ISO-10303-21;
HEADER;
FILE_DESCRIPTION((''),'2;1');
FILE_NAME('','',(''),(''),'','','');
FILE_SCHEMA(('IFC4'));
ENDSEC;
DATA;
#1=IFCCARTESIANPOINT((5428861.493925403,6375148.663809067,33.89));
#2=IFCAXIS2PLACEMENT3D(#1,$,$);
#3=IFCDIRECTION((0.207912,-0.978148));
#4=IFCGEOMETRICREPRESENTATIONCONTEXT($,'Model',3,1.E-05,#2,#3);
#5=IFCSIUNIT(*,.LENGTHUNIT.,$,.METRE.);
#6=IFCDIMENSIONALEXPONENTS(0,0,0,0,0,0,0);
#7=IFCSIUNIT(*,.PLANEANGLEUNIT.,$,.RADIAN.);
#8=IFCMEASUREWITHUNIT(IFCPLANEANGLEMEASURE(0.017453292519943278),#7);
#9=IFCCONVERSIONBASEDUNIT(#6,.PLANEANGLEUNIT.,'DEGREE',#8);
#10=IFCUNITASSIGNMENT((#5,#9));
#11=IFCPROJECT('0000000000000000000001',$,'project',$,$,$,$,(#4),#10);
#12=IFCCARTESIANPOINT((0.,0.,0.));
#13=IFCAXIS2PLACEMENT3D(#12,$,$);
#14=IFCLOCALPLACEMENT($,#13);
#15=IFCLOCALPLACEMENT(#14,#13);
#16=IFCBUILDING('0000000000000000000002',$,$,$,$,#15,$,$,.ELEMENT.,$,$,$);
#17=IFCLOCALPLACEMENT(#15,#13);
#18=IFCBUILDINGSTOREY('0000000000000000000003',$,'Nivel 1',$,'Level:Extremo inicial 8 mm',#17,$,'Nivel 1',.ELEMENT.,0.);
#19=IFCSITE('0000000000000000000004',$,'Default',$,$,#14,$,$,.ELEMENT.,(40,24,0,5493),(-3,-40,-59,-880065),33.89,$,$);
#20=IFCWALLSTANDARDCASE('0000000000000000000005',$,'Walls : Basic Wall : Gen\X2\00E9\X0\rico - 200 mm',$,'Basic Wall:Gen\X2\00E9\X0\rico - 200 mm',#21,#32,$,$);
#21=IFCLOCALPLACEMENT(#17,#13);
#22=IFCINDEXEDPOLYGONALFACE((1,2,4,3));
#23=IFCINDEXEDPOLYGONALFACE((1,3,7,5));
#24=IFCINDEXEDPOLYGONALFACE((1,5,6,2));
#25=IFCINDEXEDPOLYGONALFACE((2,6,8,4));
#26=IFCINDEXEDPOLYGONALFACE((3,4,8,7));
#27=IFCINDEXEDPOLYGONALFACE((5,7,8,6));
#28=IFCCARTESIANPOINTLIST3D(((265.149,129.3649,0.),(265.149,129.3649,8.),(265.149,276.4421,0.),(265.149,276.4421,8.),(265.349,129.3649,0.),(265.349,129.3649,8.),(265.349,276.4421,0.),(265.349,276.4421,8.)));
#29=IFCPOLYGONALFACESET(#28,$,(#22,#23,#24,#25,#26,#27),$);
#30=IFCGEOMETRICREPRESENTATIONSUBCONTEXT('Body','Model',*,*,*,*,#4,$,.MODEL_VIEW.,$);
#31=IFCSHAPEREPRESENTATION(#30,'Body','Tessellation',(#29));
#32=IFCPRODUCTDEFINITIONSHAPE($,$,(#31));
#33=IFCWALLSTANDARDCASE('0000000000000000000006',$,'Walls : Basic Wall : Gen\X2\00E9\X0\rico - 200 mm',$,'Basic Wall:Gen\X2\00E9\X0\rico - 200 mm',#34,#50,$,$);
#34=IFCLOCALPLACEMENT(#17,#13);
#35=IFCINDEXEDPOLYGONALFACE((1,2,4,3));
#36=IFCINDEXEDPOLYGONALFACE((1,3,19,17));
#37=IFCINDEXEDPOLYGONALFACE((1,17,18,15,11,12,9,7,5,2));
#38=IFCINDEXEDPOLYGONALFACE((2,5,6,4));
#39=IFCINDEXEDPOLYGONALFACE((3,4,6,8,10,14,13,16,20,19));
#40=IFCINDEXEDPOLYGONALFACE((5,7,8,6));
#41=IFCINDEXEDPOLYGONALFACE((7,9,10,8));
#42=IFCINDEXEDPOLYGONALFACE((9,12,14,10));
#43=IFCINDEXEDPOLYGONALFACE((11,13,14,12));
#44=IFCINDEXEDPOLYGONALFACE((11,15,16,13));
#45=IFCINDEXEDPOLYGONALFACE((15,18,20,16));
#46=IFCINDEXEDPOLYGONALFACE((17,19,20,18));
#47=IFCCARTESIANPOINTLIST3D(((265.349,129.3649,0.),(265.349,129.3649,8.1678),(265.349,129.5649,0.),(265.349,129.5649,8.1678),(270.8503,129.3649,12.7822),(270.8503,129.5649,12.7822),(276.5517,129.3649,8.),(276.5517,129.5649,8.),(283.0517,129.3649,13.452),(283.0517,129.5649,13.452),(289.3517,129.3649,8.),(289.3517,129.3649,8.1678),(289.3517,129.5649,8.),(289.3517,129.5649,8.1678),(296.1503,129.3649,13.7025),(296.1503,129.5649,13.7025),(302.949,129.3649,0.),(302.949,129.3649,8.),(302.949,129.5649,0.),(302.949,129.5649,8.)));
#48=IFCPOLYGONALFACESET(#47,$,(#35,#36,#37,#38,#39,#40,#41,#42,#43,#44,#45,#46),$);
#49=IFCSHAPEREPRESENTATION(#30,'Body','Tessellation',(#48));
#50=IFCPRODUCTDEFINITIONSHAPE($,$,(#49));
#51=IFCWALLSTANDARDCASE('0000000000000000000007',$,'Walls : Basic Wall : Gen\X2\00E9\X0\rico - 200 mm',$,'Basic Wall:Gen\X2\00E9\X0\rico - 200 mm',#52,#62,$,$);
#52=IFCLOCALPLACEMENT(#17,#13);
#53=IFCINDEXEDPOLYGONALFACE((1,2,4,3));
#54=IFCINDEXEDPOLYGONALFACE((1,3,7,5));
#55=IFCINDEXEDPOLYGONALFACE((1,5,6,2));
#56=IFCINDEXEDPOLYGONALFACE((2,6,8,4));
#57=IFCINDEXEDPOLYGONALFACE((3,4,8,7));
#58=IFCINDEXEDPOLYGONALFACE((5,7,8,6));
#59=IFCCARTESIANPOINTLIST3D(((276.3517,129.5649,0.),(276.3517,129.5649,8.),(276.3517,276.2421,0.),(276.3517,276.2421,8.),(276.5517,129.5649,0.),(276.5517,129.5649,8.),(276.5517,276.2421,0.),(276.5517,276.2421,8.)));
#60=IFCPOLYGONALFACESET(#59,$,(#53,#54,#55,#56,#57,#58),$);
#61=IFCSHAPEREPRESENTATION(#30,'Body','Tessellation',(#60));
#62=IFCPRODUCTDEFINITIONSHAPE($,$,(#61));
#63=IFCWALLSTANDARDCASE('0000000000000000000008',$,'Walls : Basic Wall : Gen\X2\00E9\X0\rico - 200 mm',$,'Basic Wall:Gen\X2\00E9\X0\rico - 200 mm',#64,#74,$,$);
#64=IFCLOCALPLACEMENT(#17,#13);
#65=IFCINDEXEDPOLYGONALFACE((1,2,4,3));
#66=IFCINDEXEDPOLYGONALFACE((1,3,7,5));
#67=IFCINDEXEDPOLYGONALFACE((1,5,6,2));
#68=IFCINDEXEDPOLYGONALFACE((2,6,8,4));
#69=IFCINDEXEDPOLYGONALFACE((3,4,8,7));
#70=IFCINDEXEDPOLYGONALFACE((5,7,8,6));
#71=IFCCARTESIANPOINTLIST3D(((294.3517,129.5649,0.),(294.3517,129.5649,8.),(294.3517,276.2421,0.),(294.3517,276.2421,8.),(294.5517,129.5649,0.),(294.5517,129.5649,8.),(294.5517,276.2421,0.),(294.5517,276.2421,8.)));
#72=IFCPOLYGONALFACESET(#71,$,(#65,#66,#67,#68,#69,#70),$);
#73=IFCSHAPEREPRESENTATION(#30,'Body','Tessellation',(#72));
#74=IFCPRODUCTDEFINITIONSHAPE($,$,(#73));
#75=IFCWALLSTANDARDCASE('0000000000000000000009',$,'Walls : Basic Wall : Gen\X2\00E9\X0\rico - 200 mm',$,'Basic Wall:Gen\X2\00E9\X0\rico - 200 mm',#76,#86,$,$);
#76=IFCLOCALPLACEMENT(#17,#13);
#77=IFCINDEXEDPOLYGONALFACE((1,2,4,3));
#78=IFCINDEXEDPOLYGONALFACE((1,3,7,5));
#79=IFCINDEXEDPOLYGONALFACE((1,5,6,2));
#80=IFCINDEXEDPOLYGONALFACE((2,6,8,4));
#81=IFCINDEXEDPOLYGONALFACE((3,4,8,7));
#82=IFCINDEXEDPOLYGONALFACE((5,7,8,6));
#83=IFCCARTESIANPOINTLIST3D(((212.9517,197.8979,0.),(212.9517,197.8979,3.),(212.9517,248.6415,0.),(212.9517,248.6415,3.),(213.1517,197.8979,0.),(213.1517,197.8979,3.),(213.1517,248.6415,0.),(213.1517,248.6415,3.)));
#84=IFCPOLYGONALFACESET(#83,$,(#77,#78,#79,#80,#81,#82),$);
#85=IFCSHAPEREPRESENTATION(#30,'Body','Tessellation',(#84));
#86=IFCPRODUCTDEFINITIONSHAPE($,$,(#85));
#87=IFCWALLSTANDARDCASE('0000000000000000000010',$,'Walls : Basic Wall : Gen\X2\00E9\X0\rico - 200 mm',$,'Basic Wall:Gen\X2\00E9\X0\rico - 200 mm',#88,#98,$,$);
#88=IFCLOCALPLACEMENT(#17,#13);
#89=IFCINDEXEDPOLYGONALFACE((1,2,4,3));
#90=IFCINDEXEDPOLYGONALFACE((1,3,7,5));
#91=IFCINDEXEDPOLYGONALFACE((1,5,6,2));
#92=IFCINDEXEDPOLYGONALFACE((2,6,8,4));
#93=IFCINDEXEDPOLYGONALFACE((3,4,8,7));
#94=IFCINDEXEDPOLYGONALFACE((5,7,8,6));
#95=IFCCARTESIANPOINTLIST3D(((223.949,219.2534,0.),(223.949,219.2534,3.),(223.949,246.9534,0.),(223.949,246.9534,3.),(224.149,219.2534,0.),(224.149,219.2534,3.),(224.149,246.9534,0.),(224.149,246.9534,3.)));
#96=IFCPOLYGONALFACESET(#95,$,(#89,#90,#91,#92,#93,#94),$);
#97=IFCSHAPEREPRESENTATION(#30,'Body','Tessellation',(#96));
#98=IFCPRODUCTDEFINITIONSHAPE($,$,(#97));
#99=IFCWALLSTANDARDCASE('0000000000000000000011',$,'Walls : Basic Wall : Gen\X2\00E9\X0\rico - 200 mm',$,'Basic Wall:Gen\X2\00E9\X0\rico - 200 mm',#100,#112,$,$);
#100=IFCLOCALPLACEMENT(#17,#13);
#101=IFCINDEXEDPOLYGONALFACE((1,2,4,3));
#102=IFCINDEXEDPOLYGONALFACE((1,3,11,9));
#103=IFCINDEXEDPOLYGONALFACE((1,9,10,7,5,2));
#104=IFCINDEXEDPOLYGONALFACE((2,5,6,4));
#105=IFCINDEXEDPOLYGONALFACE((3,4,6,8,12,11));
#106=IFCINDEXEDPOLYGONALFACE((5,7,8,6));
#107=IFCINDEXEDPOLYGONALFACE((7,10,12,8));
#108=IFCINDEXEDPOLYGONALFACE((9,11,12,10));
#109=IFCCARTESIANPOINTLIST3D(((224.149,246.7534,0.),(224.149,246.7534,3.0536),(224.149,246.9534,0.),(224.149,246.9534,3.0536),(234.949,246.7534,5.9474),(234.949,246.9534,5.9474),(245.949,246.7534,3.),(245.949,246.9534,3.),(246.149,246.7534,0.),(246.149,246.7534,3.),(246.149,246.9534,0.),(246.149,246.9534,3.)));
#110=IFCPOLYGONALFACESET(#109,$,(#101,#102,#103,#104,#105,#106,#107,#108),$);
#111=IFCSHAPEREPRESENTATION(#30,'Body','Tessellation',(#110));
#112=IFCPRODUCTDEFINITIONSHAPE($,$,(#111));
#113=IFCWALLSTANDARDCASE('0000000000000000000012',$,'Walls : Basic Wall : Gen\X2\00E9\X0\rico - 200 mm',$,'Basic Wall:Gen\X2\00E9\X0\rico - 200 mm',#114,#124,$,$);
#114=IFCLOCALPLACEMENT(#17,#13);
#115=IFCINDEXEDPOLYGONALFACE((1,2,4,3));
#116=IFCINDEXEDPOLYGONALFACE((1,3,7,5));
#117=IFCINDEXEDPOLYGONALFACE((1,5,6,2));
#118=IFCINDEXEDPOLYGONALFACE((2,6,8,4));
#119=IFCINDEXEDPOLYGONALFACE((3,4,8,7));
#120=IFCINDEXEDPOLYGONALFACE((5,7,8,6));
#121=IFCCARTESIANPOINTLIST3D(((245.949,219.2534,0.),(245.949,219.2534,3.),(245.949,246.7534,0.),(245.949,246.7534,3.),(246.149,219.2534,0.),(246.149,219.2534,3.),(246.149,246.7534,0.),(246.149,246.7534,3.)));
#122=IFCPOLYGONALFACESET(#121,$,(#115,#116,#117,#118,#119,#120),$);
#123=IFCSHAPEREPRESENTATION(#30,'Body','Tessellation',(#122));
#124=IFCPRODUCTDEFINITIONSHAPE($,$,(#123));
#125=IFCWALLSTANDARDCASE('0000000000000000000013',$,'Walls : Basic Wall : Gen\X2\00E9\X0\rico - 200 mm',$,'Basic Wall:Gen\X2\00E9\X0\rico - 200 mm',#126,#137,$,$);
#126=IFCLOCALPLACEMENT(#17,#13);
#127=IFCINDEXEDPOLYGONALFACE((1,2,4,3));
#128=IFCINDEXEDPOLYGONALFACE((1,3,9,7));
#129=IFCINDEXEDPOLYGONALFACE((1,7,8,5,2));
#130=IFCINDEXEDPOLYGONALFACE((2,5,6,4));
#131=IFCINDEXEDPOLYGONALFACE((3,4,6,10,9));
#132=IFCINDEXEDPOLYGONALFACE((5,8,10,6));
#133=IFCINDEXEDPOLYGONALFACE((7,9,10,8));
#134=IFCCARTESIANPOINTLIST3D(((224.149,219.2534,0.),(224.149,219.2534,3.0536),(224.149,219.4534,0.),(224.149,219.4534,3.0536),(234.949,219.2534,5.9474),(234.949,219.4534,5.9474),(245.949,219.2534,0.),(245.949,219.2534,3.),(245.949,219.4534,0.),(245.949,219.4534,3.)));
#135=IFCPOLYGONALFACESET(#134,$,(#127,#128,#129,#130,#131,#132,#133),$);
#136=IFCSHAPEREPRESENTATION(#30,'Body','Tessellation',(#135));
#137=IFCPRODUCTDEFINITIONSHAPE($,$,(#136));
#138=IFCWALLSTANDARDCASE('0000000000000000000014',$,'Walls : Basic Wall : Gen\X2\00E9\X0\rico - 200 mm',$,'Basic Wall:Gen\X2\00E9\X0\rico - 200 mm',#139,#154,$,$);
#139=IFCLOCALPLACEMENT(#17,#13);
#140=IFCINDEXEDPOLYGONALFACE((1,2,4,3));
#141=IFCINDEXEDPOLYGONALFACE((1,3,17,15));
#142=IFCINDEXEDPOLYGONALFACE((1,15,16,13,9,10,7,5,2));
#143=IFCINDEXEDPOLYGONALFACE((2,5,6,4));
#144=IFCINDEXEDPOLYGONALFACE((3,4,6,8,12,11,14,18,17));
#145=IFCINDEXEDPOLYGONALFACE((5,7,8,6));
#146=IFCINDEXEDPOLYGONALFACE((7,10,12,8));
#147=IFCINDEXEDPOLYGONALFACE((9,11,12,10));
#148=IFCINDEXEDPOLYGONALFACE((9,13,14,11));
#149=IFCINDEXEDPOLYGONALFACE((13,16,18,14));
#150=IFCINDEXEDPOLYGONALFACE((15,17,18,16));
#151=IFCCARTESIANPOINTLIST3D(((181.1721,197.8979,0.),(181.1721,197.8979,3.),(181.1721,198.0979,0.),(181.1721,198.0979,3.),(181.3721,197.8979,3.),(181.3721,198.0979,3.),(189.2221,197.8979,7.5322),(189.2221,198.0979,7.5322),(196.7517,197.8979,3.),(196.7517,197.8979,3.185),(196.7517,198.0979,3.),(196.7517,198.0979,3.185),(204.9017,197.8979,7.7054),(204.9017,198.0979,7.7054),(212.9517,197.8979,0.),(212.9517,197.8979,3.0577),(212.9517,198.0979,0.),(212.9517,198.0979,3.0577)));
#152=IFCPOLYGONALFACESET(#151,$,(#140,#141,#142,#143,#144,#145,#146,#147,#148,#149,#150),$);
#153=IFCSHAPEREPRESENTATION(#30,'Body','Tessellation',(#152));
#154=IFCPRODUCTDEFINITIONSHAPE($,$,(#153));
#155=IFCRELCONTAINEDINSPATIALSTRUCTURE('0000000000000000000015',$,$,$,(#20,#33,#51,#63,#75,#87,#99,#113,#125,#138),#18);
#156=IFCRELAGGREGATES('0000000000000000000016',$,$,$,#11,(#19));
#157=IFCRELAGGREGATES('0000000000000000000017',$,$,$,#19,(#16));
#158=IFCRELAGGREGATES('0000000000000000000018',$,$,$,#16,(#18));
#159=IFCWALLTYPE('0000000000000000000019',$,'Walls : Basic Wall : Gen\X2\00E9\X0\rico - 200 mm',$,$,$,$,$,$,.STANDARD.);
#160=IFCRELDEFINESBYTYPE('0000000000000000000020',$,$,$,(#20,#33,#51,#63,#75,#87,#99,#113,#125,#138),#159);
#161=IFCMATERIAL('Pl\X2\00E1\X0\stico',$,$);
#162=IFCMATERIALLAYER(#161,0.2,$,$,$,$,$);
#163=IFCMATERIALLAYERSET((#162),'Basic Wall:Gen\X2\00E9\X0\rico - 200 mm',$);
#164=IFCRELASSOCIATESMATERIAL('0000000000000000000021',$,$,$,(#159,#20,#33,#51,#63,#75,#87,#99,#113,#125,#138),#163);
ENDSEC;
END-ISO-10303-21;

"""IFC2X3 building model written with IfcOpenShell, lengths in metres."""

from ifc_helpers import new_model, entity, si_unit, converted_unit, direction, frame, frame_2d, origin, place, context, subcontext, project, spatial, polyline, rectangle, extrude, clip, bounded_halfspace, material, layer, layer_set, layer_usage, type_object, element, save


model = new_model("IFC2X3")

# Units and contexts
model_context = context("Model", 3, precision=1e-05, world=frame((5428861.493925403, 6375148.663809067, 33.89)), true_north=direction((0.207912, -0.978148)))
body_context = subcontext(model_context, "Body", "Model", "MODEL_VIEW")
ifc_project = project(units=[si_unit("LENGTHUNIT", "METRE"), converted_unit("PLANEANGLEUNIT", "DEGREE", entity("IfcPlaneAngleMeasure", 0.017453292519943278), si_unit("PLANEANGLEUNIT", "RADIAN"), dimensions=[0, 0, 0, 0, 0, 0, 0])], contexts=[model_context])

# Site, building, storey
site_placement = place(None, origin())
site = spatial("IfcSite", under=ifc_project, at=site_placement, Name="Default", CompositionType="ELEMENT", RefLatitude=(40, 24, 0, 5493), RefLongitude=(-3, -40, -59, -880065), RefElevation=33.89)
building_placement = place(site_placement, origin())
building = spatial("IfcBuilding", under=site, at=building_placement, CompositionType="ELEMENT")
storey_placement = place(building_placement, origin())
storey = spatial("IfcBuildingStorey", under=building, at=storey_placement, Name="Nivel 1", ObjectType="Level:Extremo inicial 8 mm", LongName="Nivel 1", CompositionType="ELEMENT", Elevation=0.0)

# Walls
ifc_material_1 = material(Name="Plástico")
ifc_layer_1 = layer(ifc_material_1, 0.2)
ifc_layer_set_1 = layer_set([ifc_layer_1], Name="Basic Wall:Genérico - 200 mm")
ifc_layer_usage_1 = layer_usage(ifc_layer_set_1, "AXIS2", "NEGATIVE", 0.1)
wall_type = type_object("IfcWallType", Name="Walls : Basic Wall : Genérico - 200 mm", PredefinedType="STANDARD", material=ifc_layer_set_1)
wall_1_placement = place(storey_placement, frame((265.249, 129.3649, 0.0), z_axis=(0.0, 0.0, 1.0), x_axis=(0.0, 1.0, 0.0)))
element("IfcWallStandardCase", 1, at=wall_1_placement, inside=storey, type_object=wall_type, material=ifc_layer_usage_1, Name="Walls : Basic Wall : Genérico - 200 mm", ObjectType="Basic Wall:Genérico - 200 mm", context=body_context, shape_type="SweptSolid", body=[
    extrude(rectangle(XDim=147.0772, YDim=0.2, at=frame_2d((73.5386, 0.0), x_axis=(-1.0, 0.0))), origin(), (0.0, 0.0, 1.0), 8.0),
])
ifc_layer_usage_2 = layer_usage(ifc_layer_set_1, "AXIS2", "NEGATIVE", 0.1)
wall_2_placement = place(storey_placement, frame((302.949, 129.4649, 0.0), z_axis=(0.0, 0.0, 1.0), x_axis=(-1.0, 0.0, 0.0)))
element("IfcWallStandardCase", 2, at=wall_2_placement, inside=storey, type_object=wall_type, material=ifc_layer_usage_2, Name="Walls : Basic Wall : Genérico - 200 mm", ObjectType="Basic Wall:Genérico - 200 mm", context=body_context, shape_type="Clipping", body=[
    clip(clip(clip(clip(clip(clip(extrude(rectangle(XDim=37.6, YDim=0.2, at=frame_2d((18.8, 0.0), x_axis=(-1.0, 0.0))), origin(), (0.0, 0.0, 1.0), 13.7025), bounded_halfspace(frame((32.0986, -0.1, 12.7822), z_axis=(0.642641, 0.0, 0.766167), x_axis=(0.0, 1.0, 0.0)), False, frame((32.0986, -0.1, 12.7822)), polyline([(0.0, 0.0), (5.5014, 0.0), (5.5014, 0.2), (0.0, 0.2), (0.0, 0.0)]))), bounded_halfspace(frame((19.8973, -0.1, 13.452), z_axis=(0.642641, 0.0, 0.766167), x_axis=(0.0, 1.0, 0.0)), False, frame((19.8973, -0.1, 13.452)), polyline([(0.0, 0.0), (6.5, 0.0), (6.5, 0.2), (0.0, 0.2), (0.0, 0.0)]))), bounded_halfspace(frame((13.5973, -0.1, 8.0), z_axis=(0.642641, 0.0, 0.766167), x_axis=(0.0, 1.0, 0.0)), False, frame((13.5973, -0.1, 8.0)), polyline([(0.0, 0.0), (0.0, 0.2), (-6.7986, 0.2), (-6.7986, 0.0), (0.0, 0.0)]))), bounded_halfspace(frame((26.3973, -0.1, 8.0), z_axis=(-0.642641, 0.0, 0.766167), x_axis=(0.0, -1.0, 0.0)), False, frame((26.3973, -0.1, 8.0)), polyline([(0.0, 0.0), (5.7014, 0.0), (5.7014, 0.2), (0.0, 0.2), (0.0, 0.0)]))), bounded_halfspace(frame((13.5973, -0.1, 8.1678), z_axis=(-0.642641, 0.0, 0.766167), x_axis=(0.0, -1.0, 0.0)), False, frame((13.5973, -0.1, 8.1678)), polyline([(0.0, 0.0), (6.3, 0.0), (6.3, 0.2), (0.0, 0.2), (0.0, 0.0)]))), bounded_halfspace(frame((6.7986, 0.1, 13.7025), z_axis=(-0.642641, 0.0, 0.766167), x_axis=(0.0, -1.0, 0.0)), False, frame((6.7986, 0.1, 13.7025)), polyline([(0.0, 0.0), (-6.7986, 0.0), (-6.7986, -0.2), (0.0, -0.2), (0.0, 0.0)]))),
])
ifc_layer_usage_3 = layer_usage(ifc_layer_set_1, "AXIS2", "NEGATIVE", 0.1)
wall_3_placement = place(storey_placement, frame((276.4517, 129.5649, 0.0), z_axis=(0.0, 0.0, 1.0), x_axis=(0.0, 1.0, 0.0)))
element("IfcWallStandardCase", 3, at=wall_3_placement, inside=storey, type_object=wall_type, material=ifc_layer_usage_3, Name="Walls : Basic Wall : Genérico - 200 mm", ObjectType="Basic Wall:Genérico - 200 mm", context=body_context, shape_type="SweptSolid", body=[
    extrude(rectangle(XDim=146.6772, YDim=0.2, at=frame_2d((73.3386, 0.0), x_axis=(-1.0, 0.0))), origin(), (0.0, 0.0, 1.0), 8.0),
])
ifc_layer_usage_4 = layer_usage(ifc_layer_set_1, "AXIS2", "NEGATIVE", 0.1)
wall_4_placement = place(storey_placement, frame((294.4517, 129.5649, 0.0), z_axis=(0.0, 0.0, 1.0), x_axis=(0.0, 1.0, 0.0)))
element("IfcWallStandardCase", 4, at=wall_4_placement, inside=storey, type_object=wall_type, material=ifc_layer_usage_4, Name="Walls : Basic Wall : Genérico - 200 mm", ObjectType="Basic Wall:Genérico - 200 mm", context=body_context, shape_type="SweptSolid", body=[
    extrude(rectangle(XDim=146.6772, YDim=0.2, at=frame_2d((73.3386, 0.0), x_axis=(-1.0, 0.0))), origin(), (0.0, 0.0, 1.0), 8.0),
])
ifc_layer_usage_5 = layer_usage(ifc_layer_set_1, "AXIS2", "NEGATIVE", 0.1)
wall_5_placement = place(storey_placement, frame((213.0517, 248.6415, 0.0), z_axis=(0.0, 0.0, 1.0), x_axis=(0.0, -1.0, 0.0)))
element("IfcWallStandardCase", 5, at=wall_5_placement, inside=storey, type_object=wall_type, material=ifc_layer_usage_5, Name="Walls : Basic Wall : Genérico - 200 mm", ObjectType="Basic Wall:Genérico - 200 mm", context=body_context, shape_type="SweptSolid", body=[
    extrude(rectangle(XDim=50.7436, YDim=0.2, at=frame_2d((25.3718, 0.0), x_axis=(-1.0, 0.0))), origin(), (0.0, 0.0, 1.0), 3.0),
])
ifc_layer_usage_6 = layer_usage(ifc_layer_set_1, "AXIS2", "NEGATIVE", 0.1)
wall_6_placement = place(storey_placement, frame((224.049, 219.2534, 0.0), z_axis=(0.0, 0.0, 1.0), x_axis=(0.0, 1.0, 0.0)))
element("IfcWallStandardCase", 6, at=wall_6_placement, inside=storey, type_object=wall_type, material=ifc_layer_usage_6, Name="Walls : Basic Wall : Genérico - 200 mm", ObjectType="Basic Wall:Genérico - 200 mm", context=body_context, shape_type="SweptSolid", body=[
    extrude(rectangle(XDim=27.7, YDim=0.2, at=frame_2d((13.85, 0.0), x_axis=(-1.0, 0.0))), origin(), (0.0, 0.0, 1.0), 3.0),
])
ifc_layer_usage_7 = layer_usage(ifc_layer_set_1, "AXIS2", "NEGATIVE", 0.1)
wall_7_placement = place(storey_placement, frame((224.149, 246.8534, 0.0)))
element("IfcWallStandardCase", 7, at=wall_7_placement, inside=storey, type_object=wall_type, material=ifc_layer_usage_7, Name="Walls : Basic Wall : Genérico - 200 mm", ObjectType="Basic Wall:Genérico - 200 mm", context=body_context, shape_type="Clipping", body=[
    clip(clip(clip(extrude(rectangle(XDim=22.0, YDim=0.2, at=frame_2d((11.0, 0.0), x_axis=(-1.0, 0.0))), origin(), (0.0, 0.0, 1.0), 5.9474), bounded_halfspace(frame((0.0, -0.1, 3.0536), z_axis=(-0.258819, 0.0, 0.965926), x_axis=(0.0, -1.0, 0.0)), False, frame((0.0, -0.1, 3.0536)), polyline([(0.0, 0.0), (10.8, 0.0), (10.8, 0.2), (0.0, 0.2), (0.0, 0.0)]))), bounded_halfspace(frame((10.8, -0.1, 5.9474), z_axis=(0.258819, 0.0, 0.965926), x_axis=(0.0, 1.0, 0.0)), False, frame((10.8, -0.1, 5.9474)), polyline([(0.0, 0.0), (11.0, 0.0), (11.0, 0.2), (0.0, 0.2), (0.0, 0.0)]))), bounded_halfspace(frame((21.8, -0.1, 3.0), z_axis=(0.0, 0.0, 1.0), x_axis=(0.0, 1.0, 0.0)), False, frame((21.8, -0.1, 3.0)), polyline([(0.0, 0.0), (0.2, 0.0), (0.2, 0.2), (0.0, 0.2), (0.0, 0.0)]))),
])
ifc_layer_usage_8 = layer_usage(ifc_layer_set_1, "AXIS2", "NEGATIVE", 0.1)
wall_8_placement = place(storey_placement, frame((246.049, 246.7534, 0.0), z_axis=(0.0, 0.0, 1.0), x_axis=(0.0, -1.0, 0.0)))
element("IfcWallStandardCase", 8, at=wall_8_placement, inside=storey, type_object=wall_type, material=ifc_layer_usage_8, Name="Walls : Basic Wall : Genérico - 200 mm", ObjectType="Basic Wall:Genérico - 200 mm", context=body_context, shape_type="SweptSolid", body=[
    extrude(rectangle(XDim=27.5, YDim=0.2, at=frame_2d((13.75, 0.0), x_axis=(-1.0, 0.0))), origin(), (0.0, 0.0, 1.0), 3.0),
])
ifc_layer_usage_9 = layer_usage(ifc_layer_set_1, "AXIS2", "NEGATIVE", 0.1)
wall_9_placement = place(storey_placement, frame((245.949, 219.3534, 0.0), z_axis=(0.0, 0.0, 1.0), x_axis=(-1.0, 0.0, 0.0)))
element("IfcWallStandardCase", 9, at=wall_9_placement, inside=storey, type_object=wall_type, material=ifc_layer_usage_9, Name="Walls : Basic Wall : Genérico - 200 mm", ObjectType="Basic Wall:Genérico - 200 mm", context=body_context, shape_type="Clipping", body=[
    clip(clip(extrude(rectangle(XDim=21.8, YDim=0.2, at=frame_2d((10.9, 0.0), x_axis=(-1.0, 0.0))), origin(), (0.0, 0.0, 1.0), 5.9474), bounded_halfspace(frame((11.0, -0.1, 5.9474), z_axis=(0.258819, 0.0, 0.965926), x_axis=(0.0, 1.0, 0.0)), False, frame((11.0, -0.1, 5.9474)), polyline([(0.0, 0.0), (10.8, 0.0), (10.8, 0.2), (0.0, 0.2), (0.0, 0.0)]))), bounded_halfspace(frame((0.0, -0.1, 3.0), z_axis=(-0.258819, 0.0, 0.965926), x_axis=(0.0, -1.0, 0.0)), False, frame((0.0, -0.1, 3.0)), polyline([(0.0, 0.0), (11.0, 0.0), (11.0, 0.2), (0.0, 0.2), (0.0, 0.0)]))),
])
ifc_layer_usage_10 = layer_usage(ifc_layer_set_1, "AXIS2", "NEGATIVE", 0.1)
wall_10_placement = place(storey_placement, frame((212.9517, 197.9979, 0.0), z_axis=(0.0, 0.0, 1.0), x_axis=(-1.0, 0.0, 0.0)))
element("IfcWallStandardCase", 10, at=wall_10_placement, inside=storey, type_object=wall_type, material=ifc_layer_usage_10, Name="Walls : Basic Wall : Genérico - 200 mm", ObjectType="Basic Wall:Genérico - 200 mm", context=body_context, shape_type="Clipping", body=[
    clip(clip(clip(clip(clip(extrude(rectangle(XDim=31.7796, YDim=0.2, at=frame_2d((15.8898, 0.0), x_axis=(-1.0, 0.0))), origin(), (0.0, 0.0, 1.0), 7.7054), bounded_halfspace(frame((23.7296, -0.1, 7.5322), z_axis=(0.5, 0.0, 0.866025), x_axis=(0.0, 1.0, 0.0)), False, frame((23.7296, -0.1, 7.5322)), polyline([(0.0, 0.0), (7.85, 0.0), (7.85, 0.2), (0.0, 0.2), (0.0, 0.0)]))), bounded_halfspace(frame((16.2, -0.1, 3.0), z_axis=(0.5, 0.0, 0.866025), x_axis=(0.0, 1.0, 0.0)), False, frame((16.2, -0.1, 3.0)), polyline([(0.0, 0.0), (0.0, 0.2), (-8.15, 0.2), (-8.15, 0.0), (0.0, 0.0)]))), bounded_halfspace(frame((16.2, -0.1, 3.185), z_axis=(-0.5, 0.0, 0.866025), x_axis=(0.0, -1.0, 0.0)), False, frame((16.2, -0.1, 3.185)), polyline([(0.0, 0.0), (7.5296, 0.0), (7.5296, 0.2), (0.0, 0.2), (0.0, 0.0)]))), bounded_halfspace(frame((8.05, 0.1, 7.7054), z_axis=(-0.5, 0.0, 0.866025), x_axis=(0.0, -1.0, 0.0)), False, frame((8.05, 0.1, 7.7054)), polyline([(0.0, 0.0), (-8.05, 0.0), (-8.05, -0.2), (0.0, -0.2), (0.0, 0.0)]))), bounded_halfspace(frame((31.5796, -0.1, 3.0), z_axis=(0.0, 0.0, 1.0), x_axis=(0.0, 1.0, 0.0)), False, frame((31.5796, -0.1, 3.0)), polyline([(0.0, 0.0), (0.2, 0.0), (0.2, 0.2), (0.0, 0.2), (0.0, 0.0)]))),
])

save(model, "model.ifc")
